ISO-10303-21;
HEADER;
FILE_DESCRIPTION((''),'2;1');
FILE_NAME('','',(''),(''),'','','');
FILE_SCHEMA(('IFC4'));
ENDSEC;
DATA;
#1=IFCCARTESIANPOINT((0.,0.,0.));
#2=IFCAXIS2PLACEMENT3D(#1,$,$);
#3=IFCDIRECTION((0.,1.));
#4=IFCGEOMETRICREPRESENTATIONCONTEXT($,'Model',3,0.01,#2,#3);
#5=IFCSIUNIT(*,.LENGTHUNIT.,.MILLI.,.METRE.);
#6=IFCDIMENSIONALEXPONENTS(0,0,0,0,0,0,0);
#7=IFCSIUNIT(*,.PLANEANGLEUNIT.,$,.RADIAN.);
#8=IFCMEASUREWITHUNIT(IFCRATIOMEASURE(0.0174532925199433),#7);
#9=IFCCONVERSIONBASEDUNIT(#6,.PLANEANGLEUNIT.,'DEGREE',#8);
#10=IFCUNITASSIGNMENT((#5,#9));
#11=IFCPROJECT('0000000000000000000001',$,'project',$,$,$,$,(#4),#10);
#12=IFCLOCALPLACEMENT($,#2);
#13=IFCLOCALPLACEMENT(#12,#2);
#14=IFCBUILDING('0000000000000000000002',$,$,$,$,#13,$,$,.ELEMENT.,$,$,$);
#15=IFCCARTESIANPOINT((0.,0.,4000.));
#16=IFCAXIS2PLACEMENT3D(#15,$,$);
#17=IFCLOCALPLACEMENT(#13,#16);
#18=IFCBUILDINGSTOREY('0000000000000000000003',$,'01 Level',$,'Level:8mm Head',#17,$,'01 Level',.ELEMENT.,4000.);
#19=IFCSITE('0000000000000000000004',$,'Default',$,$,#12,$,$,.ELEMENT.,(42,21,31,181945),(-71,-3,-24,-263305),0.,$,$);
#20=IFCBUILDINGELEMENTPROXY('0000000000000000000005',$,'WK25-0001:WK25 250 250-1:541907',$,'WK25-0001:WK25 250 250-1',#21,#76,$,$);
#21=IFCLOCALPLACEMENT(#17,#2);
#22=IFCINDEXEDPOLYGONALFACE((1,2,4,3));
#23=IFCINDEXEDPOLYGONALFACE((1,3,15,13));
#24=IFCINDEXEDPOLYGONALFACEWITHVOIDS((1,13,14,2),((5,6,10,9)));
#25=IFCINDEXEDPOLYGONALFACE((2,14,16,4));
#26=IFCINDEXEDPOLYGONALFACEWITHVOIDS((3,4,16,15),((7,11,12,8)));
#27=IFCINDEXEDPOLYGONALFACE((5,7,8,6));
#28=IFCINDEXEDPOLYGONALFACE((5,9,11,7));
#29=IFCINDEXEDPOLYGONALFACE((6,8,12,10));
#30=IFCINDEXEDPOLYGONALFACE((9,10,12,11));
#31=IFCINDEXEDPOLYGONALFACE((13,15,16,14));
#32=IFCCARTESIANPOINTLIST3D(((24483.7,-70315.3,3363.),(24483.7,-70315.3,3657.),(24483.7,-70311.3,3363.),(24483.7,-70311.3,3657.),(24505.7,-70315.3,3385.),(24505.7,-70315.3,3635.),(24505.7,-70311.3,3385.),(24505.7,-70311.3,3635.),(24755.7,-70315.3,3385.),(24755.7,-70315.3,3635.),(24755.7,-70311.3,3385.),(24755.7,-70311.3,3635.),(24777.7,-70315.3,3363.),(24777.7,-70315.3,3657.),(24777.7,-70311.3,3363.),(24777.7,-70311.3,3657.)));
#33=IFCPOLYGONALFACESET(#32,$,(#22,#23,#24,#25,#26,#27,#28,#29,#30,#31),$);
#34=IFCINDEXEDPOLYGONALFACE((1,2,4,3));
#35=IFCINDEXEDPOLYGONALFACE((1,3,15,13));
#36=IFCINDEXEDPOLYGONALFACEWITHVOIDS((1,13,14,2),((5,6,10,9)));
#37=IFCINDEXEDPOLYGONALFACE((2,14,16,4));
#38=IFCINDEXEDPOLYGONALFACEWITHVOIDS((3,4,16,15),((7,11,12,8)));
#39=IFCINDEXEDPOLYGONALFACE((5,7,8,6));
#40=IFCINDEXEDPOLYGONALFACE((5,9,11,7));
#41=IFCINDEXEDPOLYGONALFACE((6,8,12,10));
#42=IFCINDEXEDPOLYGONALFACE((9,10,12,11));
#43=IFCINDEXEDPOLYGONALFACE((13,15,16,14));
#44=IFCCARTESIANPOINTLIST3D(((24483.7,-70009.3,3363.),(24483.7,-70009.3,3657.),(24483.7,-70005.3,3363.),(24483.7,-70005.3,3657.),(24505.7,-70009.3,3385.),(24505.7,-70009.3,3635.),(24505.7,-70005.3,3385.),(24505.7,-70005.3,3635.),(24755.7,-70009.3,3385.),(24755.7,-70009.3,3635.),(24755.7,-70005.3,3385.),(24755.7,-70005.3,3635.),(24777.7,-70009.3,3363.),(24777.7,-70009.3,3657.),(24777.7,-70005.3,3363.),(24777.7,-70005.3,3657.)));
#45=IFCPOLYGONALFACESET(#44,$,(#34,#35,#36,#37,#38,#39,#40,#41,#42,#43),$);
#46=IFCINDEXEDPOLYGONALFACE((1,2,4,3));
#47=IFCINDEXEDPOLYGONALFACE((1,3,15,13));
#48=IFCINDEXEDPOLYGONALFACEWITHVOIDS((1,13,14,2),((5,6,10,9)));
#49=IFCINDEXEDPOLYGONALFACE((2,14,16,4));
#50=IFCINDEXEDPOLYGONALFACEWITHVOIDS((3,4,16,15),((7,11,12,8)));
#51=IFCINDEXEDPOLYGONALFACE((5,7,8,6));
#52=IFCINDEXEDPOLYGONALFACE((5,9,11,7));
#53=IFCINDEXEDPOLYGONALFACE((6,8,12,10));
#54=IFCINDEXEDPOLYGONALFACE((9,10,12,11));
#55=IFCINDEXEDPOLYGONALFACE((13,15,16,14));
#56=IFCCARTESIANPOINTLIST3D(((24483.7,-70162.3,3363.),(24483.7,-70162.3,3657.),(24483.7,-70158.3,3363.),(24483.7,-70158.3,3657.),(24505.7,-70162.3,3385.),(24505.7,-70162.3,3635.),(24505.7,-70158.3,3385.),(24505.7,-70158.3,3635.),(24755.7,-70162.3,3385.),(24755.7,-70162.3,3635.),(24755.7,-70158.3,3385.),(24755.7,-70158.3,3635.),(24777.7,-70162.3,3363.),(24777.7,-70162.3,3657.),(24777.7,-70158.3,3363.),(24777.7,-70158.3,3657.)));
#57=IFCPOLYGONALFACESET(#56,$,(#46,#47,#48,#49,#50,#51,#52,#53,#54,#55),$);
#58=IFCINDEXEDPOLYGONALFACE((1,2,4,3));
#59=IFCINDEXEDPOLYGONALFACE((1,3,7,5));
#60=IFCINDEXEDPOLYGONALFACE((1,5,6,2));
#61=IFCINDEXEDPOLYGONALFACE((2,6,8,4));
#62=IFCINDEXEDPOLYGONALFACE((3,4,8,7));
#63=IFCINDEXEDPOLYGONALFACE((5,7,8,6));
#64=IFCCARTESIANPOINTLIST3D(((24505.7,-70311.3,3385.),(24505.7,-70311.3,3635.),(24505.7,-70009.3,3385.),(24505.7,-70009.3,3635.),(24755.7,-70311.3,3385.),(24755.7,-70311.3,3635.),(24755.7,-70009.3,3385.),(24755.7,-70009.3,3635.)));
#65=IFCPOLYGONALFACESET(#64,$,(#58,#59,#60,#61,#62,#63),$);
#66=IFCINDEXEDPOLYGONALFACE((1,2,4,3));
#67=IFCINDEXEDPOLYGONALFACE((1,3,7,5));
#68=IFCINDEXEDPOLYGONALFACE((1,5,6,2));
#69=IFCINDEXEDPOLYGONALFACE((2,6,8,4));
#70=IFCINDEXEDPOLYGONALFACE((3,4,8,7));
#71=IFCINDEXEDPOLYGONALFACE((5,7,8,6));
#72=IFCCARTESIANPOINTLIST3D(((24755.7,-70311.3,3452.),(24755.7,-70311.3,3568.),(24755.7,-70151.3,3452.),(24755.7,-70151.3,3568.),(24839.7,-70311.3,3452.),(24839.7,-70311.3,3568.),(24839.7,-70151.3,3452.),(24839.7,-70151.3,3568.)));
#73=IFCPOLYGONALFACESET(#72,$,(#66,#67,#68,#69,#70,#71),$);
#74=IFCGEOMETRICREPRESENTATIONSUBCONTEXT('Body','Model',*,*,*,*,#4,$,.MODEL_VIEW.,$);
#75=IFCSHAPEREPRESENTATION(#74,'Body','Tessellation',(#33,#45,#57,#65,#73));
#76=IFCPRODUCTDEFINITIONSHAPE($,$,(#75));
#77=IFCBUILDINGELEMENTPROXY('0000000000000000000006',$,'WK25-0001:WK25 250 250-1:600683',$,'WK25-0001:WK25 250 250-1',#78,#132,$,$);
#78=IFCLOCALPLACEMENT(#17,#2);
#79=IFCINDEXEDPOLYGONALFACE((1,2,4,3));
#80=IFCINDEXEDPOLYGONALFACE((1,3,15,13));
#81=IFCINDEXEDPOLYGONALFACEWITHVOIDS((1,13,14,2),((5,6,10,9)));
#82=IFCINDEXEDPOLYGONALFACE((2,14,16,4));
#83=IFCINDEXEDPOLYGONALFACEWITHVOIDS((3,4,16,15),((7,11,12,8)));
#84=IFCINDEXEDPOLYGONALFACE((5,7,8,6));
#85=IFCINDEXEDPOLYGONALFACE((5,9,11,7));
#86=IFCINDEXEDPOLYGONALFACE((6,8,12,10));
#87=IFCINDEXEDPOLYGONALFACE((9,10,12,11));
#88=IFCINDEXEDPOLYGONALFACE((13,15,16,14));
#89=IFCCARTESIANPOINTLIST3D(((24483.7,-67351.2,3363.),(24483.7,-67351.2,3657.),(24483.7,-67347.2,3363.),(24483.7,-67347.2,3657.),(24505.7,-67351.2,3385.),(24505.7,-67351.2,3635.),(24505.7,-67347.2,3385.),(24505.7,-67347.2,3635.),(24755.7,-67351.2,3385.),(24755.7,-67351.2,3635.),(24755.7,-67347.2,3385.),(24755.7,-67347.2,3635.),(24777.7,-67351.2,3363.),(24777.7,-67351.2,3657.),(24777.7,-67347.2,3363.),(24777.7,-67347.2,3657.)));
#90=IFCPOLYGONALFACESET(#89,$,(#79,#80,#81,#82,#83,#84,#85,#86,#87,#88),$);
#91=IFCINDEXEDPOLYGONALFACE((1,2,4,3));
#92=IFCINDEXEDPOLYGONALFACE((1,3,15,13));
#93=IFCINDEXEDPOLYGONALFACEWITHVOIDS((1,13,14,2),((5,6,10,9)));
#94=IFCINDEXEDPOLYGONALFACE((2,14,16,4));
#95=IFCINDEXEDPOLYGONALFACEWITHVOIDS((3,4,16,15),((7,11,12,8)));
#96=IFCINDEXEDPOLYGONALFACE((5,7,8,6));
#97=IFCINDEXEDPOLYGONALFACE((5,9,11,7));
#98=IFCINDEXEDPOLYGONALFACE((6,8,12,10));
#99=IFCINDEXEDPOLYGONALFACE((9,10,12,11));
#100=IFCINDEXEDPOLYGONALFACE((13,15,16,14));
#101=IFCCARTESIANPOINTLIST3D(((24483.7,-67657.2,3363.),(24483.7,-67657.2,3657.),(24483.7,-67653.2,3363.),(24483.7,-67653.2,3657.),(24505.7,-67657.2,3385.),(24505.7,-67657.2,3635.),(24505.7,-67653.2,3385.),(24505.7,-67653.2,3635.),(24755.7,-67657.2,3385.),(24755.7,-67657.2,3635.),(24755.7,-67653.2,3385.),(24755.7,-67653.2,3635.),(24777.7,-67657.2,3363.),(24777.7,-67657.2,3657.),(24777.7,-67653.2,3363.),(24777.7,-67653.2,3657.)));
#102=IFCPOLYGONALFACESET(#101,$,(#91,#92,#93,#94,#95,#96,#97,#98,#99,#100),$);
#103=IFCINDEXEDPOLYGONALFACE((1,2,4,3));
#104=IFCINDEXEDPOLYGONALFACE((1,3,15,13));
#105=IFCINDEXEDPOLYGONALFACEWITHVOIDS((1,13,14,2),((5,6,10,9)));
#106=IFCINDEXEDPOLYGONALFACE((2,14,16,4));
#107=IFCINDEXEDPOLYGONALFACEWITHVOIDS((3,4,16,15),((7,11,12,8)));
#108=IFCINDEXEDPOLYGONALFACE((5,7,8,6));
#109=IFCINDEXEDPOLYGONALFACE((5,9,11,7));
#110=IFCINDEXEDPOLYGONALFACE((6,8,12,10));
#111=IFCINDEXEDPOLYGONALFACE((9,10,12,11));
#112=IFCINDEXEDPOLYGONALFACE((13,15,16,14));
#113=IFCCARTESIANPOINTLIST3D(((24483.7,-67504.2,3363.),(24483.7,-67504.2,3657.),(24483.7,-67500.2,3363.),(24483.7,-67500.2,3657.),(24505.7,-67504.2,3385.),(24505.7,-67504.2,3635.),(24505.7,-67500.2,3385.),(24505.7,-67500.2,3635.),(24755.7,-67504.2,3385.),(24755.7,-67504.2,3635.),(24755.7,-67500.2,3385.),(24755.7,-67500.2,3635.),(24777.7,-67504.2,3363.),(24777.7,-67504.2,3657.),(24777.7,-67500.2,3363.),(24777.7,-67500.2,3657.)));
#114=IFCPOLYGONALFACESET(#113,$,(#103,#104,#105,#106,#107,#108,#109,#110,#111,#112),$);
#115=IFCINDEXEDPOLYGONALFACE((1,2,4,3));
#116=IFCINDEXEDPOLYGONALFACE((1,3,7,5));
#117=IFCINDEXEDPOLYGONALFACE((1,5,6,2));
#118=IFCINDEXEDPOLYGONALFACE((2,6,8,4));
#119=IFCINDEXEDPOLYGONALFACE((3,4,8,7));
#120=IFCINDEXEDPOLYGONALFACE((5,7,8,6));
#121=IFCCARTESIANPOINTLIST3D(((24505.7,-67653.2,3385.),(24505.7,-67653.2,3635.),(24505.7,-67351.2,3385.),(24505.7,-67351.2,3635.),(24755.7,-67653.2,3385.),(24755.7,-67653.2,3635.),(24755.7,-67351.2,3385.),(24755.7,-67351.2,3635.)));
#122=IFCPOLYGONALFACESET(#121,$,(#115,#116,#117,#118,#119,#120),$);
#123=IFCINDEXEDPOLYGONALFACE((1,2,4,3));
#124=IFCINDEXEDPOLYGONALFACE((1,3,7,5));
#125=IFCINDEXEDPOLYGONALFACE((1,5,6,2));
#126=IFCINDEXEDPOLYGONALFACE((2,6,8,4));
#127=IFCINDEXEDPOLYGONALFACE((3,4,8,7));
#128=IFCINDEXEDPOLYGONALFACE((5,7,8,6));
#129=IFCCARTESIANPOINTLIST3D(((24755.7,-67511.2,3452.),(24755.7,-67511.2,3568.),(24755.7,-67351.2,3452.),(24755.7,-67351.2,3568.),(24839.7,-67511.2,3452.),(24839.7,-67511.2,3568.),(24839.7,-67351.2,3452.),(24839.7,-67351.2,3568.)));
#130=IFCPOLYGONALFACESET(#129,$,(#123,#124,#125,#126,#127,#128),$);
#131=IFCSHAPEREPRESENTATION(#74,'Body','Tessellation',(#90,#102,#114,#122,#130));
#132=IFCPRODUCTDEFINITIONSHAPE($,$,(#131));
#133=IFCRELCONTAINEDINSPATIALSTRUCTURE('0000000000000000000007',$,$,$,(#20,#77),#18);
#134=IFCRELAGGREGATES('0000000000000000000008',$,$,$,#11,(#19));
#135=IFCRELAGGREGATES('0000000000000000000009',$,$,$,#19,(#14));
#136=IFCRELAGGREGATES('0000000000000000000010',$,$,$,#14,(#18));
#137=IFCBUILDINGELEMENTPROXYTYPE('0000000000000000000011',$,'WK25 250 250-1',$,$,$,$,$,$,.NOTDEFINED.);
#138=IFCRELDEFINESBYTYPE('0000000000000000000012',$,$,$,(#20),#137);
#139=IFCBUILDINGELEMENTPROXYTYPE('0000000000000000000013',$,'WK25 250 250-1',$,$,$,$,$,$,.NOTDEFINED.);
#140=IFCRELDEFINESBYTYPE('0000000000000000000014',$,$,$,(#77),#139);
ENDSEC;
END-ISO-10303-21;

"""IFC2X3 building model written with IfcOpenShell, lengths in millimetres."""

from ifc_helpers import new_model, entity, si_unit, converted_unit, direction, frame, frame_2d, origin, origin_2d_with_axis, place, context, subcontext, project, spatial, polyline, rectangle, outline, extrude, source, transform, mapped, type_object, type_shapes, element, save


model = new_model("IFC2X3")

# Units and contexts
model_context = context("Model", 3, precision=0.01, world=origin(), true_north=direction((0.0, 1.0)))
body_context = subcontext(model_context, "Body", "Model", "MODEL_VIEW")
ifc_project = project(units=[si_unit("LENGTHUNIT", "METRE", prefix="MILLI"), converted_unit("PLANEANGLEUNIT", "DEGREE", entity("IfcRatioMeasure", 0.0174532925199433), si_unit("PLANEANGLEUNIT", "RADIAN"), dimensions=[0, 0, 0, 0, 0, 0, 0])], contexts=[model_context])

# Site, building, storey
site_placement = place(None, origin())
site = spatial("IfcSite", under=ifc_project, at=site_placement, Name="Default", CompositionType="ELEMENT", RefLatitude=(42, 21, 31, 181945), RefLongitude=(-71, -3, -24, -263305), RefElevation=0.0)
building_placement = place(site_placement, origin())
building = spatial("IfcBuilding", under=site, at=building_placement, CompositionType="ELEMENT")
storey_placement = place(building_placement, frame((0.0, 0.0, 4000.0)))
storey = spatial("IfcBuildingStorey", under=building, at=storey_placement, Name="01 Level", ObjectType="Level:8mm Head", LongName="01 Level", CompositionType="ELEMENT", Elevation=4000.0)

# Building element proxies
building_element_proxy_type_1 = type_object("IfcBuildingElementProxyType", Name="WK25 250 250-1", PredefinedType="NOTDEFINED")
shared_shape_1 = source(origin(), body_context, "Body", "SweptSolid", [
    extrude(outline(polyline([(-147.0, -147.0), (147.0, -147.0), (147.0, 147.0), (-147.0, 147.0), (-147.0, -147.0)]), holes=[polyline([(-125.0, -125.0), (-125.0, 125.0), (125.0, 125.0), (125.0, -125.0), (-125.0, -125.0)])]), frame((151.0, 0.0, 0.0), z_axis=(1.0, 0.0, 0.0), x_axis=(0.0, 0.0, -1.0)), (0.0, 0.0, 1.0), 4.0),
    extrude(outline(polyline([(-147.0, -147.0), (147.0, -147.0), (147.0, 147.0), (-147.0, 147.0), (-147.0, -147.0)]), holes=[polyline([(-125.0, -125.0), (-125.0, 125.0), (125.0, 125.0), (125.0, -125.0), (-125.0, -125.0)])]), frame((-155.0, 0.0, 0.0), z_axis=(1.0, 0.0, 0.0), x_axis=(0.0, -1.0, 0.0)), (0.0, 0.0, 1.0), 4.0),
    extrude(outline(polyline([(-147.0, -147.0), (147.0, -147.0), (147.0, 147.0), (-147.0, 147.0), (-147.0, -147.0)]), holes=[polyline([(-125.0, -125.0), (-125.0, 125.0), (125.0, 125.0), (125.0, -125.0), (-125.0, -125.0)])]), frame((-2.0, 0.0, 0.0), z_axis=(1.0, 0.0, 0.0), x_axis=(0.0, -1.0, 0.0)), (0.0, 0.0, 1.0), 4.0),
    extrude(rectangle(XDim=302.0, YDim=250.0, at=origin_2d_with_axis()), frame((0.0, 0.0, -125.0), z_axis=(0.0, 0.0, 1.0), x_axis=(-1.0, 0.0, 0.0)), (0.0, 0.0, 1.0), 250.0),
    extrude(rectangle(XDim=84.0, YDim=160.0, at=frame_2d((0.0, 0.0), x_axis=(1.0, 0.0))), frame((71.0, -167.0, -58.0), z_axis=(0.0, 0.0, 1.0), x_axis=(0.0, -1.0, 0.0)), (0.0, 0.0, 1.0), 116.0),
])
type_shapes(building_element_proxy_type_1, [shared_shape_1])
proxy_1_placement = place(storey_placement, frame((24630.7, -70160.3, 3510.0), z_axis=(0.0, 0.0, -1.0), x_axis=(0.0, -1.0, 0.0)))
element("IfcBuildingElementProxy", 1, at=proxy_1_placement, inside=storey, type_object=building_element_proxy_type_1, Name="WK25-0001:WK25 250 250-1:541907", ObjectType="WK25-0001:WK25 250 250-1", context=body_context, shape_type="MappedRepresentation", body=[
    mapped(shared_shape_1, transform((0.0, 0.0, 0.0), scale=1.0)),
])
building_element_proxy_type_2 = type_object("IfcBuildingElementProxyType", Name="WK25 250 250-1", PredefinedType="NOTDEFINED")
shared_shape_2 = source(origin(), body_context, "Body", "SweptSolid", [
    extrude(outline(polyline([(-147.0, -147.0), (147.0, -147.0), (147.0, 147.0), (-147.0, 147.0), (-147.0, -147.0)]), holes=[polyline([(-125.0, -125.0), (-125.0, 125.0), (125.0, 125.0), (125.0, -125.0), (-125.0, -125.0)])]), frame((151.0, 0.0, 0.0), z_axis=(1.0, 0.0, 0.0), x_axis=(0.0, -1.0, 0.0)), (0.0, 0.0, 1.0), 4.0),
    extrude(outline(polyline([(-147.0, -147.0), (147.0, -147.0), (147.0, 147.0), (-147.0, 147.0), (-147.0, -147.0)]), holes=[polyline([(-125.0, -125.0), (-125.0, 125.0), (125.0, 125.0), (125.0, -125.0), (-125.0, -125.0)])]), frame((-155.0, 0.0, 0.0), z_axis=(1.0, 0.0, 0.0), x_axis=(0.0, 0.0, -1.0)), (0.0, 0.0, 1.0), 4.0),
    extrude(outline(polyline([(-147.0, -147.0), (147.0, -147.0), (147.0, 147.0), (-147.0, 147.0), (-147.0, -147.0)]), holes=[polyline([(-125.0, -125.0), (-125.0, 125.0), (125.0, 125.0), (125.0, -125.0), (-125.0, -125.0)])]), frame((-2.0, 0.0, 0.0), z_axis=(1.0, 0.0, 0.0), x_axis=(0.0, 0.0, -1.0)), (0.0, 0.0, 1.0), 4.0),
    extrude(rectangle(XDim=250.0, YDim=302.0, at=origin_2d_with_axis()), frame((0.0, 0.0, -125.0), z_axis=(0.0, 0.0, 1.0), x_axis=(0.0, 1.0, 0.0)), (0.0, 0.0, 1.0), 250.0),
    extrude(rectangle(XDim=160.0, YDim=84.0, at=frame_2d((0.0, 0.0), x_axis=(1.0, 0.0))), frame((71.0, 167.0, -58.0)), (0.0, 0.0, 1.0), 116.0),
])
type_shapes(building_element_proxy_type_2, [shared_shape_2])
proxy_2_placement = place(storey_placement, frame((24630.7, -67502.2, 3510.0), z_axis=(0.0, 0.0, -1.0), x_axis=(0.0, 1.0, 0.0)))
element("IfcBuildingElementProxy", 2, at=proxy_2_placement, inside=storey, type_object=building_element_proxy_type_2, Name="WK25-0001:WK25 250 250-1:600683", ObjectType="WK25-0001:WK25 250 250-1", context=body_context, shape_type="MappedRepresentation", body=[
    mapped(shared_shape_2, transform((0.0, 0.0, 0.0), scale=1.0)),
])

save(model, "model.ifc")
